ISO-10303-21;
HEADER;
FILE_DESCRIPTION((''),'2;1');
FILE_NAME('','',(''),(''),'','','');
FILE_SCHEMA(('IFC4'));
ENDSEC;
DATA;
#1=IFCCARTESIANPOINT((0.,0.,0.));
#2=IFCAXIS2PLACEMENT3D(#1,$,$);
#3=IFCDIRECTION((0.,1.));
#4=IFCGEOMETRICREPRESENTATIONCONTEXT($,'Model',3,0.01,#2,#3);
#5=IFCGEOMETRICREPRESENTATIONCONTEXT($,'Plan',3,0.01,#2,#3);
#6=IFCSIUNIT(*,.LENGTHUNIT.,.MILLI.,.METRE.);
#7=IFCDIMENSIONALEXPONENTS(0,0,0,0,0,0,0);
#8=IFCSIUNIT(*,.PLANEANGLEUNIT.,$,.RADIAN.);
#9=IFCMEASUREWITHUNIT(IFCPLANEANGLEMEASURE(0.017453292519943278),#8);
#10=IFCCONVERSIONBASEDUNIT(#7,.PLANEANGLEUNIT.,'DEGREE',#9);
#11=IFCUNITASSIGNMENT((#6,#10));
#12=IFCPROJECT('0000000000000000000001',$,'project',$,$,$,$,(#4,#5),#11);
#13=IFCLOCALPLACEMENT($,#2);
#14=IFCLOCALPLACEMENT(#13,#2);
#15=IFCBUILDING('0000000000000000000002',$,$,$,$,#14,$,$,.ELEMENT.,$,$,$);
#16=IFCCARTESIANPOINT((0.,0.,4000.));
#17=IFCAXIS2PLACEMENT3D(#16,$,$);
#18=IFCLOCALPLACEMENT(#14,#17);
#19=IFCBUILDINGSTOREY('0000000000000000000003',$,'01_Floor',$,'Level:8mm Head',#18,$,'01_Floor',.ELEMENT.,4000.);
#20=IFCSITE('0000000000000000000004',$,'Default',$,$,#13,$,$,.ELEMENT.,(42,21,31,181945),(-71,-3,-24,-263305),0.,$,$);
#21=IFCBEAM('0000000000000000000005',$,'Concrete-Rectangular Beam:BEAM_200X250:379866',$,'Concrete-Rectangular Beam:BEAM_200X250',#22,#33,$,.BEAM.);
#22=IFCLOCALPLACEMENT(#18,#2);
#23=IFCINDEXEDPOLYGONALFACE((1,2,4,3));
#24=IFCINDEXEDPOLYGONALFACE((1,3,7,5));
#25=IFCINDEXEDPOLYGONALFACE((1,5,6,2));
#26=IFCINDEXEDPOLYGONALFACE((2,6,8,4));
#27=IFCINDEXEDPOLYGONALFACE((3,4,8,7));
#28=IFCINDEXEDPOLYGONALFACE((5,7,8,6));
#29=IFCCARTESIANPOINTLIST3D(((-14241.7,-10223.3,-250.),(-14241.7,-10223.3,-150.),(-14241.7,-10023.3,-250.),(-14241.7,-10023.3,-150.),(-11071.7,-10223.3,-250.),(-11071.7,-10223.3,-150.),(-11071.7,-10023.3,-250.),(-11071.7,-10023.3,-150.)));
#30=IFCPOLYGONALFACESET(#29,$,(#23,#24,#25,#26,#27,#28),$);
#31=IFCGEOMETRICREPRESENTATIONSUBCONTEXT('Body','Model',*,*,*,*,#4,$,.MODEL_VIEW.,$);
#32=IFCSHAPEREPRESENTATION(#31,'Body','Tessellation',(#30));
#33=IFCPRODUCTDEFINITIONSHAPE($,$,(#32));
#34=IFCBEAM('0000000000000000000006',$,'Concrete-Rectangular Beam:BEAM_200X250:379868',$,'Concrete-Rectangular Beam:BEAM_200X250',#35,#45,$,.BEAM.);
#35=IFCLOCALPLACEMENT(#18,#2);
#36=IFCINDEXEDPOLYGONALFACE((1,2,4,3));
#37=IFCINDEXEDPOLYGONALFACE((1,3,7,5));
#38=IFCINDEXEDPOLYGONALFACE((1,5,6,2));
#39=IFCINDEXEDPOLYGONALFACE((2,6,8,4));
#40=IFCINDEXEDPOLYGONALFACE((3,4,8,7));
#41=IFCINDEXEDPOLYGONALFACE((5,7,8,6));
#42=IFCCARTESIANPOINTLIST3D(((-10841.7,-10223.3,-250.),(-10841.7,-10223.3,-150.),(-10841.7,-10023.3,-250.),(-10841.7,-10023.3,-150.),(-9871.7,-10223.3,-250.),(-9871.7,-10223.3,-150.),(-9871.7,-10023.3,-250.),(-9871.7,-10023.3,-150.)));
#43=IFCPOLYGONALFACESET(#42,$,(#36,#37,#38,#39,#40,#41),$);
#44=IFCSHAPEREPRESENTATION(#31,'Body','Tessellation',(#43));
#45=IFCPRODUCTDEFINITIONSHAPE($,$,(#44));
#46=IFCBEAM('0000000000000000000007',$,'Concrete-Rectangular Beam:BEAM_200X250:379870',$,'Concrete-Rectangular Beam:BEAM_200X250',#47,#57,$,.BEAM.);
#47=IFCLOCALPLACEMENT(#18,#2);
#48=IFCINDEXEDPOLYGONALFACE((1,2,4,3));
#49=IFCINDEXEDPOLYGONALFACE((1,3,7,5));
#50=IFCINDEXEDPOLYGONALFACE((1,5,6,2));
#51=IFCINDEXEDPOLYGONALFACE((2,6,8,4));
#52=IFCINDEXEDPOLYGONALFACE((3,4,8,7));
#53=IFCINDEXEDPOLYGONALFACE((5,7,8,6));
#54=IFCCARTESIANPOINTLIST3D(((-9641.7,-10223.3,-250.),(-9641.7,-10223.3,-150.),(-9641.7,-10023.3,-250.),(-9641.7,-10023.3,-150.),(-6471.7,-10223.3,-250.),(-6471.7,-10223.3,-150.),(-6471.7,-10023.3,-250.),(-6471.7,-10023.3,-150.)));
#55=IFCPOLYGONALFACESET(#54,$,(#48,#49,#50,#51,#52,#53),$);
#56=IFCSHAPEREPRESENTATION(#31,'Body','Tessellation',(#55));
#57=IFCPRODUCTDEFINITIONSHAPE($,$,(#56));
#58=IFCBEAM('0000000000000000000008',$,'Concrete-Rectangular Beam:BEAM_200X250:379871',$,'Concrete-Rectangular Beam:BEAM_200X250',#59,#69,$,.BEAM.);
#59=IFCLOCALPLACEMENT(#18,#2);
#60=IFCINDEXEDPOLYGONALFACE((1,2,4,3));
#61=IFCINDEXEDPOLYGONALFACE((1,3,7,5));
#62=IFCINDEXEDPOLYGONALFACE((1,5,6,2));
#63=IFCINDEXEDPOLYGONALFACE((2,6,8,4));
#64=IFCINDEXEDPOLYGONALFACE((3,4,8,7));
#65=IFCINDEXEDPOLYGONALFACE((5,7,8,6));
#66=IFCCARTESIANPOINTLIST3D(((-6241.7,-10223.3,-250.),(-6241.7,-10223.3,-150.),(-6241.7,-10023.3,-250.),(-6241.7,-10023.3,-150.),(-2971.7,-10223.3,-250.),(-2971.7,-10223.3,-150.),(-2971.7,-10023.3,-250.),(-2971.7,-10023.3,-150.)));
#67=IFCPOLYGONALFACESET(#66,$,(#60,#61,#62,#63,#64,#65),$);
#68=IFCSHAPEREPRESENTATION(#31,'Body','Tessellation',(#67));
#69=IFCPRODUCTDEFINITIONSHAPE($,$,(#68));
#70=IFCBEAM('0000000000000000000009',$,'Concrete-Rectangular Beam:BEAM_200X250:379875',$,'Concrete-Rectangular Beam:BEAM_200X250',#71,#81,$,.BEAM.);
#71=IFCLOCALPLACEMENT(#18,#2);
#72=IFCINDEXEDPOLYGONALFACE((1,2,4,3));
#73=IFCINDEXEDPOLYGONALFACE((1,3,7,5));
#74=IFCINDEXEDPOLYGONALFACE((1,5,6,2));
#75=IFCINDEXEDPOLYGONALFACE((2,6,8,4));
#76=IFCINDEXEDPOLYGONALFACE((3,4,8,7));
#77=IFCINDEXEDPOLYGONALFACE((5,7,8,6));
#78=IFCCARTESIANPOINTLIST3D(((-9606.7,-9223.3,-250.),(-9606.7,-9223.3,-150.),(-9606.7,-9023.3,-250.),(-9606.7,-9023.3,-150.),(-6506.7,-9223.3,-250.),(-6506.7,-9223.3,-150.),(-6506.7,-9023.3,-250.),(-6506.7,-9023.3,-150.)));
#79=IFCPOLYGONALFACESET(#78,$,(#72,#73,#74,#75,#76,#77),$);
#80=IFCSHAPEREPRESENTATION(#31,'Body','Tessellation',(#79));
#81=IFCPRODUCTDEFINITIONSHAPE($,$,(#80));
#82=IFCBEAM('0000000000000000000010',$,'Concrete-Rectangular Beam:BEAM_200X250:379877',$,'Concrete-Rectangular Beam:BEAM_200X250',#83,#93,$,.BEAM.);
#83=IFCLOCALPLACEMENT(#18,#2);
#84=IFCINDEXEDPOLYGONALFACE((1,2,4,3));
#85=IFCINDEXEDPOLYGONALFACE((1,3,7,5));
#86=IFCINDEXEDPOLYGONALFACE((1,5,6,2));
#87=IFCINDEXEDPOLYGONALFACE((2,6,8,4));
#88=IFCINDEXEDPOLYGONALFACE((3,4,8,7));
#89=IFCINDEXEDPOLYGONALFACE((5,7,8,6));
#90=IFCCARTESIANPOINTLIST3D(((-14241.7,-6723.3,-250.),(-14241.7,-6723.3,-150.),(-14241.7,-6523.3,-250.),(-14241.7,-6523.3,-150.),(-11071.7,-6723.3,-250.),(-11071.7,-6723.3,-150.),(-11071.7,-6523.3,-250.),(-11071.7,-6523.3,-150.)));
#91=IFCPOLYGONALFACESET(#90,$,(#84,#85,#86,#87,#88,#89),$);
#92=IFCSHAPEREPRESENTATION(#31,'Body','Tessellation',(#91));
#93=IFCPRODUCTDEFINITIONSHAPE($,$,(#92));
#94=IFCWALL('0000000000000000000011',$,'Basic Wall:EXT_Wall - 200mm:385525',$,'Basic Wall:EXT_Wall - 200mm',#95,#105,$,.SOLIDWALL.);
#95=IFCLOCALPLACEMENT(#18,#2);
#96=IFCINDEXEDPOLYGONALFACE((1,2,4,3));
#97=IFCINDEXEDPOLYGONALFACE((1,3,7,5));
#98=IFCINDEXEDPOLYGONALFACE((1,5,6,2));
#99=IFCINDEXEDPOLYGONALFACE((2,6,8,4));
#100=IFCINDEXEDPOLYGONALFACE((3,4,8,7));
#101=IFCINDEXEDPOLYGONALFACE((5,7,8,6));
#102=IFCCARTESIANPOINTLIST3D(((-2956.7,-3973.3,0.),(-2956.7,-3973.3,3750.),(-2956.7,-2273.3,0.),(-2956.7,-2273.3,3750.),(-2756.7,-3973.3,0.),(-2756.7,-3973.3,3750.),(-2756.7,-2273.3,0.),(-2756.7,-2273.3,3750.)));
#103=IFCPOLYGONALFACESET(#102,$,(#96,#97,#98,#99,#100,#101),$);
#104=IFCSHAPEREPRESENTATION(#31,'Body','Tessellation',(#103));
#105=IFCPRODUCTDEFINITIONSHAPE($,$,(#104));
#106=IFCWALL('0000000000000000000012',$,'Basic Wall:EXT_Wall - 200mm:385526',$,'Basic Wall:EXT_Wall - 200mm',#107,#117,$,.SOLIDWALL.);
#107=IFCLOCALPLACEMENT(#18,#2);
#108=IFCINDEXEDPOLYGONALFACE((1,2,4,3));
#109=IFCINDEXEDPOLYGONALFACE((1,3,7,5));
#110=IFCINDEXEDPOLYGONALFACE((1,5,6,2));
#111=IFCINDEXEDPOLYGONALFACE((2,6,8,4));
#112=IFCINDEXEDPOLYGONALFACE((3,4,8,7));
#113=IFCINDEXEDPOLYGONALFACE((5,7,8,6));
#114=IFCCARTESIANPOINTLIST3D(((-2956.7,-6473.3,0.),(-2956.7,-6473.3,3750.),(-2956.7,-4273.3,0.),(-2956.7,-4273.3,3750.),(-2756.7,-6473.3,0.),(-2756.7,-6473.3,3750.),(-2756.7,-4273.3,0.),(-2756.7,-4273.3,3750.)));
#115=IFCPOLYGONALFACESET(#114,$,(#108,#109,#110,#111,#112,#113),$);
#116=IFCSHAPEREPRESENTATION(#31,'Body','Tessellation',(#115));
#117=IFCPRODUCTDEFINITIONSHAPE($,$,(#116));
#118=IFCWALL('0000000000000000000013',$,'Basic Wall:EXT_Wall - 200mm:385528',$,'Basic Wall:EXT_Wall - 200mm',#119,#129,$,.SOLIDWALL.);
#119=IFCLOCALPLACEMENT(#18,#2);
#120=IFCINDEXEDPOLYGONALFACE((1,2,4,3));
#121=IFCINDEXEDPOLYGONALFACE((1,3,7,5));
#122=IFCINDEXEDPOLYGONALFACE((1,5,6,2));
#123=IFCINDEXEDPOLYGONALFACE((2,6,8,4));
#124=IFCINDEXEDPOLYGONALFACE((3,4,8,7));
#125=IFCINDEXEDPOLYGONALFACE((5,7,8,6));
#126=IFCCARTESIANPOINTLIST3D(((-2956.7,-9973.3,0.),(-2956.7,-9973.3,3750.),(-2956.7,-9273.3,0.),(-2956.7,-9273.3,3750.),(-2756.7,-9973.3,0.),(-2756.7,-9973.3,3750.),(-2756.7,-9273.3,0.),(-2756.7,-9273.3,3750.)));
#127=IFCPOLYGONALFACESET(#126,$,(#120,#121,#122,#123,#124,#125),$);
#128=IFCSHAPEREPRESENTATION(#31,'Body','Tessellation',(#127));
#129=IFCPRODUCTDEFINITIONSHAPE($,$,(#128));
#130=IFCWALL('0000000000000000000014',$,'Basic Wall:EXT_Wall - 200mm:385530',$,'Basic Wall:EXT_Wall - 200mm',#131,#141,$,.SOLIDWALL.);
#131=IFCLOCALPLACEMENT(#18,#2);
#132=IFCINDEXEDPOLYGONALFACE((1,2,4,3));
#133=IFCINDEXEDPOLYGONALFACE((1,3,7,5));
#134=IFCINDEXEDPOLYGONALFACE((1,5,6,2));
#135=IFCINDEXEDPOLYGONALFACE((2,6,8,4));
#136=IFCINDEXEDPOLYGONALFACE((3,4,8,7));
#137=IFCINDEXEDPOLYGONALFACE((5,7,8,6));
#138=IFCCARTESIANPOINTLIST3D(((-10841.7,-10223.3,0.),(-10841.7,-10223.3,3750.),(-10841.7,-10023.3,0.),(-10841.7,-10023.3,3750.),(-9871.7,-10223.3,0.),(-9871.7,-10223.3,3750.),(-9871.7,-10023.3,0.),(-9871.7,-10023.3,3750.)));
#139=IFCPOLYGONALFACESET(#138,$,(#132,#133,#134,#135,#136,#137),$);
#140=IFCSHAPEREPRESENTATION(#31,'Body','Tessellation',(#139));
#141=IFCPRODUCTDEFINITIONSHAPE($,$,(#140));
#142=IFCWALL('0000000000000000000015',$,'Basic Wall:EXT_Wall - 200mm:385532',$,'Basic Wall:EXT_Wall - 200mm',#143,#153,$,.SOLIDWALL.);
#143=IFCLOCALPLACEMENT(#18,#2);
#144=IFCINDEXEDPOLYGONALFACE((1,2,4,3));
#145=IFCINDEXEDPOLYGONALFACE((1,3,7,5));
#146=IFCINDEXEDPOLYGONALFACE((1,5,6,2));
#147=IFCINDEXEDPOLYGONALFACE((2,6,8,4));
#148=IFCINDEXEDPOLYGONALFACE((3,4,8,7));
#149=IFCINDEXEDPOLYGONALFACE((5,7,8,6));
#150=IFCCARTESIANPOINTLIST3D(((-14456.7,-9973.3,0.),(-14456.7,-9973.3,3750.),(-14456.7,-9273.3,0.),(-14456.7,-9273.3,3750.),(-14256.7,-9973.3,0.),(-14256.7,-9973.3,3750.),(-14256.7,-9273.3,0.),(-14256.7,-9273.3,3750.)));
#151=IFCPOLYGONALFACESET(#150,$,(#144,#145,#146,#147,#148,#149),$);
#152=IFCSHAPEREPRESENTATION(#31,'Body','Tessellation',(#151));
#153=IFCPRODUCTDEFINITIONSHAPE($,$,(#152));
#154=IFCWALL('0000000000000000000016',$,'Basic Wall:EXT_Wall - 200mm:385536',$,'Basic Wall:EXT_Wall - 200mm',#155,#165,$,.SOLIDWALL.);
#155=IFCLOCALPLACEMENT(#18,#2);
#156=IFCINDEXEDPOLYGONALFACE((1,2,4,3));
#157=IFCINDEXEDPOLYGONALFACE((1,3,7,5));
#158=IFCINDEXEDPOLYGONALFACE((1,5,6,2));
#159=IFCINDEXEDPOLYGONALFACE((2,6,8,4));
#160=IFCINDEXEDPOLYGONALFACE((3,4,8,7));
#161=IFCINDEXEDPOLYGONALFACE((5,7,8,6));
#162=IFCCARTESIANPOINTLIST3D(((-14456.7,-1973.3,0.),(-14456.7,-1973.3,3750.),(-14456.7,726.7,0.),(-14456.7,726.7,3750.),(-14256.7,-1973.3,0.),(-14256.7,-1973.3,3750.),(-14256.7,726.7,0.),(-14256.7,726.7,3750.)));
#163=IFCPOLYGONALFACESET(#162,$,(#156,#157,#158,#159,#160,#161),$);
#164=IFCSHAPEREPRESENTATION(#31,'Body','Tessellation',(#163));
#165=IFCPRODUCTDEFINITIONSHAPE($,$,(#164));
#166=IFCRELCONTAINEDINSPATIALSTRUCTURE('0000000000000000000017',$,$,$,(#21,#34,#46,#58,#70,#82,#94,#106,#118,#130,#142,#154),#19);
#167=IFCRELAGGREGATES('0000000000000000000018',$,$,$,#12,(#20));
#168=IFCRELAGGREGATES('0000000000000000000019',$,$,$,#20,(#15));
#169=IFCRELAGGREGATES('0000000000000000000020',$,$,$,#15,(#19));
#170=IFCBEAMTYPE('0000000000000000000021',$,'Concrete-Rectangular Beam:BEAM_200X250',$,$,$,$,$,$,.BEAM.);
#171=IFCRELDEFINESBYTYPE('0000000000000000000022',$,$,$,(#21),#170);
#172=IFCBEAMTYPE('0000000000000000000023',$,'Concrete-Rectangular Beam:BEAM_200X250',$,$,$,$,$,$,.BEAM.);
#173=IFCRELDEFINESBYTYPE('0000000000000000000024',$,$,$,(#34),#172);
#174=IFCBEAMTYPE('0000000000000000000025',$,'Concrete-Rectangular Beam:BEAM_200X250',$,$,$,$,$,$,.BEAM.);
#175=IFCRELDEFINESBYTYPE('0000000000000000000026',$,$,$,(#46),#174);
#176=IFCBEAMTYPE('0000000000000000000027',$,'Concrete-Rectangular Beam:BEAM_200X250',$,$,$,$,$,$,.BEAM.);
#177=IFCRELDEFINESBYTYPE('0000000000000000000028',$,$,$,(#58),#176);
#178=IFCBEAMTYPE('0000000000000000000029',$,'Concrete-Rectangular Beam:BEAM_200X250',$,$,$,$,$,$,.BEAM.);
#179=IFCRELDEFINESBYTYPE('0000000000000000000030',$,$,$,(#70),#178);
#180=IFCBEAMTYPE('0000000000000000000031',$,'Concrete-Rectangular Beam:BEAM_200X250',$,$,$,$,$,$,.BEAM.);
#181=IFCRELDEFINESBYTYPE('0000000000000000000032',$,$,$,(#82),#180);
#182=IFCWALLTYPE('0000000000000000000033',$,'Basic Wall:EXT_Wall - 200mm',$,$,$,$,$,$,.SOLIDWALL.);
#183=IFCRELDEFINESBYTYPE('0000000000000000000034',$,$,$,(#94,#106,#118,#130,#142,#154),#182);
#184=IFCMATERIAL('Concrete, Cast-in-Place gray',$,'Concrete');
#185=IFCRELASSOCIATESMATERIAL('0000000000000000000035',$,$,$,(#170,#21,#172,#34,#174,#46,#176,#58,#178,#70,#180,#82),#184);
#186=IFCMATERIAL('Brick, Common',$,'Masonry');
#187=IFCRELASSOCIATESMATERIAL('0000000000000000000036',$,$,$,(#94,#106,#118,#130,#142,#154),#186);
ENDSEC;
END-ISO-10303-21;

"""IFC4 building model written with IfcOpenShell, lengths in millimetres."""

from ifc_helpers import new_model, entity, si_unit, converted_unit, direction, frame, origin, place, context, subcontext, project, spatial, indexed_curve, outline, extrude, source, transform, mapped, material, type_object, type_shapes, element, save


model = new_model("IFC4")

# Units and contexts
model_context = context("Model", 3, precision=0.01, world=origin(), true_north=direction((0.0, 1.0)))
plan_context = context("Plan", 3, precision=0.01, world=origin(), true_north=direction((0.0, 1.0)))
body_context = subcontext(model_context, "Body", "Model", "MODEL_VIEW")
ifc_project = project(units=[si_unit("LENGTHUNIT", "METRE", prefix="MILLI"), converted_unit("PLANEANGLEUNIT", "DEGREE", entity("IfcPlaneAngleMeasure", 0.017453292519943278), si_unit("PLANEANGLEUNIT", "RADIAN"), dimensions=[0, 0, 0, 0, 0, 0, 0])], contexts=[model_context, plan_context])

# Site, building, storey
site_placement = place(None, origin())
site = spatial("IfcSite", under=ifc_project, at=site_placement, Name="Default", CompositionType="ELEMENT", RefLatitude=(42, 21, 31, 181945), RefLongitude=(-71, -3, -24, -263305), RefElevation=0.0)
building_placement = place(site_placement, origin())
building = spatial("IfcBuilding", under=site, at=building_placement, CompositionType="ELEMENT")
storey_placement = place(building_placement, frame((0.0, 0.0, 4000.0)))
storey = spatial("IfcBuildingStorey", under=building, at=storey_placement, Name="01_Floor", ObjectType="Level:8mm Head", LongName="01_Floor", CompositionType="ELEMENT", Elevation=4000.0)

# Beams
ifc_material_1 = material(Name="Concrete, Cast-in-Place gray", Category="Concrete")
beam_type_1 = type_object("IfcBeamType", Name="Concrete-Rectangular Beam:BEAM_200X250", PredefinedType="BEAM", material=ifc_material_1)
shared_shape_1 = source(origin(), body_context, "Body", "SweptSolid", [
    extrude(outline(indexed_curve([(-50.0, -100.0), (50.0, -100.0), (50.0, 100.0), (-50.0, 100.0), (-50.0, -100.0)], self_intersect=False)), frame((-14241.7, -10123.3, 3800.0), z_axis=(1.0, 0.0, 0.0), x_axis=(0.0, 0.0, -1.0)), (0.0, 0.0, 1.0), 3170.0),
])
type_shapes(beam_type_1, [shared_shape_1])
beam_1_placement = place(storey_placement, frame((0.0, 0.0, -4000.0)))
element("IfcBeam", 1, at=beam_1_placement, inside=storey, type_object=beam_type_1, material=ifc_material_1, Name="Concrete-Rectangular Beam:BEAM_200X250:379866", ObjectType="Concrete-Rectangular Beam:BEAM_200X250", PredefinedType="BEAM", context=body_context, shape_type="MappedRepresentation", body=[
    mapped(shared_shape_1, transform((0.0, 0.0, 0.0), scale=1.0)),
])
beam_type_2 = type_object("IfcBeamType", Name="Concrete-Rectangular Beam:BEAM_200X250", PredefinedType="BEAM", material=ifc_material_1)
shared_shape_2 = source(origin(), body_context, "Body", "SweptSolid", [
    extrude(outline(indexed_curve([(-50.0, -100.0), (50.0, -100.0), (50.0, 100.0), (-50.0, 100.0), (-50.0, -100.0)], self_intersect=False)), frame((-10841.7, -10123.3, 3800.0), z_axis=(1.0, 0.0, 0.0), x_axis=(0.0, 0.0, -1.0)), (0.0, 0.0, 1.0), 970.0),
])
type_shapes(beam_type_2, [shared_shape_2])
beam_2_placement = place(storey_placement, frame((0.0, 0.0, -4000.0)))
element("IfcBeam", 2, at=beam_2_placement, inside=storey, type_object=beam_type_2, material=ifc_material_1, Name="Concrete-Rectangular Beam:BEAM_200X250:379868", ObjectType="Concrete-Rectangular Beam:BEAM_200X250", PredefinedType="BEAM", context=body_context, shape_type="MappedRepresentation", body=[
    mapped(shared_shape_2, transform((0.0, 0.0, 0.0), scale=1.0)),
])
beam_type_3 = type_object("IfcBeamType", Name="Concrete-Rectangular Beam:BEAM_200X250", PredefinedType="BEAM", material=ifc_material_1)
shared_shape_3 = source(origin(), body_context, "Body", "SweptSolid", [
    extrude(outline(indexed_curve([(-50.0, -100.0), (50.0, -100.0), (50.0, 100.0), (-50.0, 100.0), (-50.0, -100.0)], self_intersect=False)), frame((-9641.7, -10123.3, 3800.0), z_axis=(1.0, 0.0, 0.0), x_axis=(0.0, 0.0, -1.0)), (0.0, 0.0, 1.0), 3170.0),
])
type_shapes(beam_type_3, [shared_shape_3])
beam_3_placement = place(storey_placement, frame((0.0, 0.0, -4000.0)))
element("IfcBeam", 3, at=beam_3_placement, inside=storey, type_object=beam_type_3, material=ifc_material_1, Name="Concrete-Rectangular Beam:BEAM_200X250:379870", ObjectType="Concrete-Rectangular Beam:BEAM_200X250", PredefinedType="BEAM", context=body_context, shape_type="MappedRepresentation", body=[
    mapped(shared_shape_3, transform((0.0, 0.0, 0.0), scale=1.0)),
])
beam_type_4 = type_object("IfcBeamType", Name="Concrete-Rectangular Beam:BEAM_200X250", PredefinedType="BEAM", material=ifc_material_1)
shared_shape_4 = source(origin(), body_context, "Body", "SweptSolid", [
    extrude(outline(indexed_curve([(-50.0, -100.0), (50.0, -100.0), (50.0, 100.0), (-50.0, 100.0), (-50.0, -100.0)], self_intersect=False)), frame((-6241.7, -10123.3, 3800.0), z_axis=(1.0, 0.0, 0.0), x_axis=(0.0, 0.0, -1.0)), (0.0, 0.0, 1.0), 3270.0),
])
type_shapes(beam_type_4, [shared_shape_4])
beam_4_placement = place(storey_placement, frame((0.0, 0.0, -4000.0)))
element("IfcBeam", 4, at=beam_4_placement, inside=storey, type_object=beam_type_4, material=ifc_material_1, Name="Concrete-Rectangular Beam:BEAM_200X250:379871", ObjectType="Concrete-Rectangular Beam:BEAM_200X250", PredefinedType="BEAM", context=body_context, shape_type="MappedRepresentation", body=[
    mapped(shared_shape_4, transform((0.0, 0.0, 0.0), scale=1.0)),
])
beam_type_5 = type_object("IfcBeamType", Name="Concrete-Rectangular Beam:BEAM_200X250", PredefinedType="BEAM", material=ifc_material_1)
shared_shape_5 = source(origin(), body_context, "Body", "SweptSolid", [
    extrude(outline(indexed_curve([(-50.0, -100.0), (50.0, -100.0), (50.0, 100.0), (-50.0, 100.0), (-50.0, -100.0)], self_intersect=False)), frame((-9606.7, -9123.3, 3800.0), z_axis=(1.0, 0.0, 0.0), x_axis=(0.0, 0.0, -1.0)), (0.0, 0.0, 1.0), 3100.0),
])
type_shapes(beam_type_5, [shared_shape_5])
beam_5_placement = place(storey_placement, frame((0.0, 0.0, -4000.0)))
element("IfcBeam", 5, at=beam_5_placement, inside=storey, type_object=beam_type_5, material=ifc_material_1, Name="Concrete-Rectangular Beam:BEAM_200X250:379875", ObjectType="Concrete-Rectangular Beam:BEAM_200X250", PredefinedType="BEAM", context=body_context, shape_type="MappedRepresentation", body=[
    mapped(shared_shape_5, transform((0.0, 0.0, 0.0), scale=1.0)),
])
beam_type_6 = type_object("IfcBeamType", Name="Concrete-Rectangular Beam:BEAM_200X250", PredefinedType="BEAM", material=ifc_material_1)
shared_shape_6 = source(origin(), body_context, "Body", "SweptSolid", [
    extrude(outline(indexed_curve([(-50.0, -100.0), (50.0, -100.0), (50.0, 100.0), (-50.0, 100.0), (-50.0, -100.0)], self_intersect=False)), frame((-14241.7, -6623.3, 3800.0), z_axis=(1.0, 0.0, 0.0), x_axis=(0.0, 0.0, -1.0)), (0.0, 0.0, 1.0), 3170.0),
])
type_shapes(beam_type_6, [shared_shape_6])
beam_6_placement = place(storey_placement, frame((0.0, 0.0, -4000.0)))
element("IfcBeam", 6, at=beam_6_placement, inside=storey, type_object=beam_type_6, material=ifc_material_1, Name="Concrete-Rectangular Beam:BEAM_200X250:379877", ObjectType="Concrete-Rectangular Beam:BEAM_200X250", PredefinedType="BEAM", context=body_context, shape_type="MappedRepresentation", body=[
    mapped(shared_shape_6, transform((0.0, 0.0, 0.0), scale=1.0)),
])

# Walls
ifc_material_2 = material(Name="Brick, Common", Category="Masonry")
wall_type_1 = type_object("IfcWallType", Name="Basic Wall:EXT_Wall - 200mm", PredefinedType="SOLIDWALL")
wall_1_placement = place(storey_placement, frame((-2856.7, -2273.3, 0.0), z_axis=(0.0, 0.0, 1.0), x_axis=(0.0, -1.0, 0.0)))
element("IfcWall", 7, at=wall_1_placement, inside=storey, type_object=wall_type_1, material=ifc_material_2, Name="Basic Wall:EXT_Wall - 200mm:385525", ObjectType="Basic Wall:EXT_Wall - 200mm", PredefinedType="SOLIDWALL", context=body_context, shape_type="SweptSolid", body=[
    extrude(outline(indexed_curve([(1700.0, 100.0), (0.0, 100.0), (0.0, -100.0), (1700.0, -100.0), (1700.0, 100.0)], self_intersect=False)), origin(), (0.0, 0.0, 1.0), 3750.0),
])
wall_2_placement = place(storey_placement, frame((-2856.7, -4273.3, 0.0), z_axis=(0.0, 0.0, 1.0), x_axis=(0.0, -1.0, 0.0)))
element("IfcWall", 8, at=wall_2_placement, inside=storey, type_object=wall_type_1, material=ifc_material_2, Name="Basic Wall:EXT_Wall - 200mm:385526", ObjectType="Basic Wall:EXT_Wall - 200mm", PredefinedType="SOLIDWALL", context=body_context, shape_type="SweptSolid", body=[
    extrude(outline(indexed_curve([(2200.0, 100.0), (0.0, 100.0), (0.0, -100.0), (2200.0, -100.0), (2200.0, 100.0)], self_intersect=False)), origin(), (0.0, 0.0, 1.0), 3750.0),
])
wall_3_placement = place(storey_placement, frame((-2856.7, -9273.3, 0.0), z_axis=(0.0, 0.0, 1.0), x_axis=(0.0, -1.0, 0.0)))
element("IfcWall", 9, at=wall_3_placement, inside=storey, type_object=wall_type_1, material=ifc_material_2, Name="Basic Wall:EXT_Wall - 200mm:385528", ObjectType="Basic Wall:EXT_Wall - 200mm", PredefinedType="SOLIDWALL", context=body_context, shape_type="SweptSolid", body=[
    extrude(outline(indexed_curve([(700.0, 100.0), (0.0, 100.0), (0.0, -100.0), (700.0, -100.0), (700.0, 100.0)], self_intersect=False)), origin(), (0.0, 0.0, 1.0), 3750.0),
])
wall_4_placement = place(storey_placement, frame((-9871.7, -10123.3, 0.0), z_axis=(0.0, 0.0, 1.0), x_axis=(-1.0, 0.0, 0.0)))
element("IfcWall", 10, at=wall_4_placement, inside=storey, type_object=wall_type_1, material=ifc_material_2, Name="Basic Wall:EXT_Wall - 200mm:385530", ObjectType="Basic Wall:EXT_Wall - 200mm", PredefinedType="SOLIDWALL", context=body_context, shape_type="SweptSolid", body=[
    extrude(outline(indexed_curve([(970.0, 100.0), (0.0, 100.0), (0.0, -100.0), (970.0, -100.0), (970.0, 100.0)], self_intersect=False)), origin(), (0.0, 0.0, 1.0), 3750.0),
])
wall_5_placement = place(storey_placement, frame((-14356.7, -9973.3, 0.0), z_axis=(0.0, 0.0, 1.0), x_axis=(0.0, 1.0, 0.0)))
element("IfcWall", 11, at=wall_5_placement, inside=storey, type_object=wall_type_1, material=ifc_material_2, Name="Basic Wall:EXT_Wall - 200mm:385532", ObjectType="Basic Wall:EXT_Wall - 200mm", PredefinedType="SOLIDWALL", context=body_context, shape_type="SweptSolid", body=[
    extrude(outline(indexed_curve([(700.0, 100.0), (0.0, 100.0), (0.0, -100.0), (700.0, -100.0), (700.0, 100.0)], self_intersect=False)), origin(), (0.0, 0.0, 1.0), 3750.0),
])
wall_6_placement = place(storey_placement, frame((-14356.7, -1973.3, 0.0), z_axis=(0.0, 0.0, 1.0), x_axis=(0.0, 1.0, 0.0)))
element("IfcWall", 12, at=wall_6_placement, inside=storey, type_object=wall_type_1, material=ifc_material_2, Name="Basic Wall:EXT_Wall - 200mm:385536", ObjectType="Basic Wall:EXT_Wall - 200mm", PredefinedType="SOLIDWALL", context=body_context, shape_type="SweptSolid", body=[
    extrude(outline(indexed_curve([(2700.0, 100.0), (0.0, 100.0), (0.0, -100.0), (2700.0, -100.0), (2700.0, 100.0)], self_intersect=False)), origin(), (0.0, 0.0, 1.0), 3750.0),
])

save(model, "model.ifc")
